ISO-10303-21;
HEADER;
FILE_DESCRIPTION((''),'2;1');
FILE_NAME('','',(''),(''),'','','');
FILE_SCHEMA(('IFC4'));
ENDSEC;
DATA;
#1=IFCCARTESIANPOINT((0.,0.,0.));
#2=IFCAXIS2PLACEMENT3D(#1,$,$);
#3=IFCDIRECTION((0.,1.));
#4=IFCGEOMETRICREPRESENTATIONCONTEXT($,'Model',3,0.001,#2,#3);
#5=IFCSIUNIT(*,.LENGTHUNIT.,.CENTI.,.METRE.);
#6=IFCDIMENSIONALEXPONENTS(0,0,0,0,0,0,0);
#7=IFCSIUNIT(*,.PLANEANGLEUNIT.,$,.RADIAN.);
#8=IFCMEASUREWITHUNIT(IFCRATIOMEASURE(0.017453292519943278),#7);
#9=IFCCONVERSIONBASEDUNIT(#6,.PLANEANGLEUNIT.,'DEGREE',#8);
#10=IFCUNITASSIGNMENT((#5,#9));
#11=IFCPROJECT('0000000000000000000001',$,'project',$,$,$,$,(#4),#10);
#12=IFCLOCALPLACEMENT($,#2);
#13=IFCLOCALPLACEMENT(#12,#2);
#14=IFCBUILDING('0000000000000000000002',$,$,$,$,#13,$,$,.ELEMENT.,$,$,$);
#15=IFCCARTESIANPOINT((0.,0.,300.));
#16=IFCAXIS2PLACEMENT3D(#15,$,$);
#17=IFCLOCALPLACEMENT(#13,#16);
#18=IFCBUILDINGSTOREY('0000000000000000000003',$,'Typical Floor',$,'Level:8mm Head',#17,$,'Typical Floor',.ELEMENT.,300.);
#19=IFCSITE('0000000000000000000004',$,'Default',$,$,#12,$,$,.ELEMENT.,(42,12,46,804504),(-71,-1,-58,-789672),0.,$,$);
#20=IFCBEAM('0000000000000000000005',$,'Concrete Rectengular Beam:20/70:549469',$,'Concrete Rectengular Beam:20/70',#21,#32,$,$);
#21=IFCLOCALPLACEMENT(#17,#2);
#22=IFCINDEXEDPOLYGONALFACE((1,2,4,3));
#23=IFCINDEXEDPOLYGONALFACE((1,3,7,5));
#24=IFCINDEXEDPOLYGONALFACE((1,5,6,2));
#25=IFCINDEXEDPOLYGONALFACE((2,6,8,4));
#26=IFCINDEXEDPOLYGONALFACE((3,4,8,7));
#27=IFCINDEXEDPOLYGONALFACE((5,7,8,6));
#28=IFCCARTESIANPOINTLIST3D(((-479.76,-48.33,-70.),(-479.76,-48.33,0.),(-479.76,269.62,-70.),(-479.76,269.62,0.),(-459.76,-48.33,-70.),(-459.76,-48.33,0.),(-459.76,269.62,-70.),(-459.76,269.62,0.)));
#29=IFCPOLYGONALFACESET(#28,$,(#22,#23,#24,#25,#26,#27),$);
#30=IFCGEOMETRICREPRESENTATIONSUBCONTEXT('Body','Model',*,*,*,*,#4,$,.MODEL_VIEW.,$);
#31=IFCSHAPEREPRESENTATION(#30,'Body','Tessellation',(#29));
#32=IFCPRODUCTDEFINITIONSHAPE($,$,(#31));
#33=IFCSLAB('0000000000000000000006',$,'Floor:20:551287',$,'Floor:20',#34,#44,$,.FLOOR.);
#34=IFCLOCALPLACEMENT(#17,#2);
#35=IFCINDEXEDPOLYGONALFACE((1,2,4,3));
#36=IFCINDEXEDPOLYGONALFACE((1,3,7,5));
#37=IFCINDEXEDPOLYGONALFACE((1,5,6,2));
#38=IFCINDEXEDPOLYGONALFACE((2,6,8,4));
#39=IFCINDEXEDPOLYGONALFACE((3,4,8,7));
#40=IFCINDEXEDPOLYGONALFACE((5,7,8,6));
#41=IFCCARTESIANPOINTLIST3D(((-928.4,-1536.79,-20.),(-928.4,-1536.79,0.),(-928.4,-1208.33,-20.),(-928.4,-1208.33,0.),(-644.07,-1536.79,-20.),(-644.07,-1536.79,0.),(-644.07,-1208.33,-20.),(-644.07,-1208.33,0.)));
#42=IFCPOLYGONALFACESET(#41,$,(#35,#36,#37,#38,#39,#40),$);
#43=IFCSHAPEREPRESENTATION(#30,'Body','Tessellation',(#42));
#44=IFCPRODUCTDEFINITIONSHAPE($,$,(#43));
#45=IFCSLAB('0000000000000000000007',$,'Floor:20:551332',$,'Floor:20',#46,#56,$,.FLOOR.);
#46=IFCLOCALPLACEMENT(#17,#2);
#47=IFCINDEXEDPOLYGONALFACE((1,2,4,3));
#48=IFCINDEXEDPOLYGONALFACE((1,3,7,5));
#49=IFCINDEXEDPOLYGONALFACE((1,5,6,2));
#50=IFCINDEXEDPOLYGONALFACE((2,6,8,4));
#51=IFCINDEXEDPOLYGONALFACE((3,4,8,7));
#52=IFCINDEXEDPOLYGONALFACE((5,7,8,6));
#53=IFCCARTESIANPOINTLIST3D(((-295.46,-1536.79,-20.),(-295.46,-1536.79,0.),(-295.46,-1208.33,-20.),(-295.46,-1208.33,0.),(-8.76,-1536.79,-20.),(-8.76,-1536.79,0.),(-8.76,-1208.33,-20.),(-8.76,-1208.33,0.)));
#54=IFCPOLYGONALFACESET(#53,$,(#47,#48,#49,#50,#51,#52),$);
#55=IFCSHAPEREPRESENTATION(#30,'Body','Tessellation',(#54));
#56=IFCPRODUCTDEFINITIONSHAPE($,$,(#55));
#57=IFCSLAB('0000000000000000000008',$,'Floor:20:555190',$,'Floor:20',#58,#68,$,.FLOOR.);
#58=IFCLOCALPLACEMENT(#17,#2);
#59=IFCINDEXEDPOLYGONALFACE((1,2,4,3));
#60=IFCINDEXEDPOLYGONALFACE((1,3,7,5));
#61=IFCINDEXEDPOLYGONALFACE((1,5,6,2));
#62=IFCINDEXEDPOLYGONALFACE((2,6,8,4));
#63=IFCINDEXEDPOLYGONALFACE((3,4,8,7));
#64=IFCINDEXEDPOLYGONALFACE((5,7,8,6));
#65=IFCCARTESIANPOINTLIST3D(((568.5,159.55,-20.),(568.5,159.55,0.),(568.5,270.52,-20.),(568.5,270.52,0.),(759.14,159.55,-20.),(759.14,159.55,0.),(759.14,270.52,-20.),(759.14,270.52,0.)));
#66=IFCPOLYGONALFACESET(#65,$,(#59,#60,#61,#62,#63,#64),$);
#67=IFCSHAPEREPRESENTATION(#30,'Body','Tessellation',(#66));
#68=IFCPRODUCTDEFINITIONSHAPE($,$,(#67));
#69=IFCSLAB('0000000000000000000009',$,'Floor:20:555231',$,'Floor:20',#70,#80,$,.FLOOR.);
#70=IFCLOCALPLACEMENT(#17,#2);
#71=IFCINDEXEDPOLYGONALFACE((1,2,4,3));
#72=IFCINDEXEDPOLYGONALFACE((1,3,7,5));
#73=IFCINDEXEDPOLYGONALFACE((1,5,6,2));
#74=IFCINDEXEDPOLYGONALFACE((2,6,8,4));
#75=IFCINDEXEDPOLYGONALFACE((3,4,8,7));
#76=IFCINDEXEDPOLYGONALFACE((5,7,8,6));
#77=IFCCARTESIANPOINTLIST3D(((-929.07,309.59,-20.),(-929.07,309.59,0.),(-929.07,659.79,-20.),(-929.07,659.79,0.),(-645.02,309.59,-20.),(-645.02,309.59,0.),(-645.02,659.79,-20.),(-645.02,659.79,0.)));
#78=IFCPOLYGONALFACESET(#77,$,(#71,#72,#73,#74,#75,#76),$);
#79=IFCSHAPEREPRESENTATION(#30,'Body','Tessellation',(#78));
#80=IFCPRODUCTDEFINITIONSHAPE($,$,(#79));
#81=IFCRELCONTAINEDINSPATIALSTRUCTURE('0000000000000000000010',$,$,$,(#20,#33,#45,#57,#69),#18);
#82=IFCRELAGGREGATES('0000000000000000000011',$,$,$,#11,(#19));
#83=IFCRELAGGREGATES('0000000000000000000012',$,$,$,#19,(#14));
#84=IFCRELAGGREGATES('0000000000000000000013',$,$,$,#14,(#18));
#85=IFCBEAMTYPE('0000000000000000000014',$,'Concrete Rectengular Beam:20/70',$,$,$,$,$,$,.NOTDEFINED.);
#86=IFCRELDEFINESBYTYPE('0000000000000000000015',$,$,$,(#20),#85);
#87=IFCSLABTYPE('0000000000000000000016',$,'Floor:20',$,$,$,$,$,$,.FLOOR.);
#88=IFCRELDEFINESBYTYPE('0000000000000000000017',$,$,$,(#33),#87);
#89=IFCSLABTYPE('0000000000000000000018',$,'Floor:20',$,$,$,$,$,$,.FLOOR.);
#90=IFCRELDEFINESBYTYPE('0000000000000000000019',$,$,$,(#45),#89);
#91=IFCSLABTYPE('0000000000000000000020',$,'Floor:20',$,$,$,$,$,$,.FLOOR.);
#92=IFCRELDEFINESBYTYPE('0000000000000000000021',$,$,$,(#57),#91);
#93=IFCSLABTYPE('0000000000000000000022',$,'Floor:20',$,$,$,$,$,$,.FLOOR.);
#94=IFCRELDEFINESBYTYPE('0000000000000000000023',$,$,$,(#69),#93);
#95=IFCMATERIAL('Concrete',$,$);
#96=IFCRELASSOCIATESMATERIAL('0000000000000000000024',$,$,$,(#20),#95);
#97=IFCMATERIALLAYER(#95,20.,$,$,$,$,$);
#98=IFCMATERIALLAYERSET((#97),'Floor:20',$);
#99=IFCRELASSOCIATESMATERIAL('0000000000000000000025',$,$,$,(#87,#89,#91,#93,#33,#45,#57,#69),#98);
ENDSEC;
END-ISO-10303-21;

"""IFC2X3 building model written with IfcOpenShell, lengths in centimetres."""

from ifc_helpers import new_model, entity, si_unit, converted_unit, direction, frame, frame_2d, origin, origin_2d_with_axis, place, context, subcontext, project, spatial, rectangle, extrude, material, layer, layer_set, layer_usage, type_object, element, save


model = new_model("IFC2X3")

# Units and contexts
model_context = context("Model", 3, precision=0.001, world=origin(), true_north=direction((0.0, 1.0)))
body_context = subcontext(model_context, "Body", "Model", "MODEL_VIEW")
ifc_project = project(units=[si_unit("LENGTHUNIT", "METRE", prefix="CENTI"), converted_unit("PLANEANGLEUNIT", "DEGREE", entity("IfcRatioMeasure", 0.017453292519943278), si_unit("PLANEANGLEUNIT", "RADIAN"), dimensions=[0, 0, 0, 0, 0, 0, 0])], contexts=[model_context])

# Site, building, storey
site_placement = place(None, origin())
site = spatial("IfcSite", under=ifc_project, at=site_placement, Name="Default", CompositionType="ELEMENT", RefLatitude=(42, 12, 46, 804504), RefLongitude=(-71, -1, -58, -789672), RefElevation=0.0)
building_placement = place(site_placement, origin())
building = spatial("IfcBuilding", under=site, at=building_placement, CompositionType="ELEMENT")
storey_placement = place(building_placement, frame((0.0, 0.0, 300.0)))
storey = spatial("IfcBuildingStorey", under=building, at=storey_placement, Name="Typical Floor", ObjectType="Level:8mm Head", LongName="Typical Floor", CompositionType="ELEMENT", Elevation=300.0)

# Beam
ifc_material = material(Name="Concrete")
beam_type_1 = type_object("IfcBeamType", Name="Concrete Rectengular Beam:20/70", PredefinedType="NOTDEFINED")
beam_1_placement = place(storey_placement, frame((-469.76, 289.62, 0.0), z_axis=(0.0, 0.0, 1.0), x_axis=(0.0, -1.0, 0.0)))
element("IfcBeam", 1, at=beam_1_placement, inside=storey, type_object=beam_type_1, material=ifc_material, Name="Concrete Rectengular Beam:20/70:549469", ObjectType="Concrete Rectengular Beam:20/70", context=body_context, shape_type="SweptSolid", body=[
    extrude(rectangle(XDim=70.0, YDim=20.0, at=frame_2d((0.0, 0.0), x_axis=(1.0, 0.0))), frame((20.0, 0.0, -35.0), z_axis=(1.0, 0.0, 0.0), x_axis=(0.0, 0.0, -1.0)), (0.0, 0.0, 1.0), 317.95),
])

# Slabs
ifc_layer = layer(ifc_material, 20.0)
ifc_layer_set = layer_set([ifc_layer], Name="Floor:20")
ifc_layer_usage_1 = layer_usage(ifc_layer_set, "AXIS3", "POSITIVE", 0.0)
slab_type_1 = type_object("IfcSlabType", Name="Floor:20", PredefinedType="FLOOR", material=ifc_layer_set)
slab_1_placement = place(storey_placement, origin())
element("IfcSlab", 2, at=slab_1_placement, inside=storey, type_object=slab_type_1, material=ifc_layer_usage_1, Name="Floor:20:551287", ObjectType="Floor:20", PredefinedType="FLOOR", context=body_context, shape_type="SweptSolid", body=[
    extrude(rectangle(XDim=328.46, YDim=284.33, at=frame_2d((0.0, 0.0), x_axis=(1.0, 0.0))), frame((-786.23, -1372.56, 0.0), z_axis=(0.0, 0.0, -1.0), x_axis=(0.0, 1.0, 0.0)), (0.0, 0.0, 1.0), 20.0),
])
ifc_layer_usage_2 = layer_usage(ifc_layer_set, "AXIS3", "POSITIVE", 0.0)
slab_type_2 = type_object("IfcSlabType", Name="Floor:20", PredefinedType="FLOOR", material=ifc_layer_set)
slab_2_placement = place(storey_placement, origin())
element("IfcSlab", 3, at=slab_2_placement, inside=storey, type_object=slab_type_2, material=ifc_layer_usage_2, Name="Floor:20:551332", ObjectType="Floor:20", PredefinedType="FLOOR", context=body_context, shape_type="SweptSolid", body=[
    extrude(rectangle(XDim=328.46, YDim=286.7, at=origin_2d_with_axis()), frame((-152.11, -1372.56, 0.0), z_axis=(0.0, 0.0, -1.0), x_axis=(0.0, 1.0, 0.0)), (0.0, 0.0, 1.0), 20.0),
])
ifc_layer_usage_3 = layer_usage(ifc_layer_set, "AXIS3", "POSITIVE", 0.0)
slab_type_3 = type_object("IfcSlabType", Name="Floor:20", PredefinedType="FLOOR", material=ifc_layer_set)
slab_3_placement = place(storey_placement, origin())
element("IfcSlab", 4, at=slab_3_placement, inside=storey, type_object=slab_type_3, material=ifc_layer_usage_3, Name="Floor:20:555190", ObjectType="Floor:20", PredefinedType="FLOOR", context=body_context, shape_type="SweptSolid", body=[
    extrude(rectangle(XDim=110.96, YDim=190.64, at=frame_2d((0.0, 0.0), x_axis=(1.0, 0.0))), frame((663.82, 215.03, 0.0), z_axis=(0.0, 0.0, -1.0), x_axis=(0.0, 1.0, 0.0)), (0.0, 0.0, 1.0), 20.0),
])
ifc_layer_usage_4 = layer_usage(ifc_layer_set, "AXIS3", "POSITIVE", 0.0)
slab_type_4 = type_object("IfcSlabType", Name="Floor:20", PredefinedType="FLOOR", material=ifc_layer_set)
slab_4_placement = place(storey_placement, origin())
element("IfcSlab", 5, at=slab_4_placement, inside=storey, type_object=slab_type_4, material=ifc_layer_usage_4, Name="Floor:20:555231", ObjectType="Floor:20", PredefinedType="FLOOR", context=body_context, shape_type="SweptSolid", body=[
    extrude(rectangle(XDim=350.2, YDim=284.05, at=frame_2d((0.0, 0.0), x_axis=(1.0, 0.0))), frame((-787.04, 484.69, 0.0), z_axis=(0.0, 0.0, -1.0), x_axis=(0.0, 1.0, 0.0)), (0.0, 0.0, 1.0), 20.0),
])

save(model, "model.ifc")
